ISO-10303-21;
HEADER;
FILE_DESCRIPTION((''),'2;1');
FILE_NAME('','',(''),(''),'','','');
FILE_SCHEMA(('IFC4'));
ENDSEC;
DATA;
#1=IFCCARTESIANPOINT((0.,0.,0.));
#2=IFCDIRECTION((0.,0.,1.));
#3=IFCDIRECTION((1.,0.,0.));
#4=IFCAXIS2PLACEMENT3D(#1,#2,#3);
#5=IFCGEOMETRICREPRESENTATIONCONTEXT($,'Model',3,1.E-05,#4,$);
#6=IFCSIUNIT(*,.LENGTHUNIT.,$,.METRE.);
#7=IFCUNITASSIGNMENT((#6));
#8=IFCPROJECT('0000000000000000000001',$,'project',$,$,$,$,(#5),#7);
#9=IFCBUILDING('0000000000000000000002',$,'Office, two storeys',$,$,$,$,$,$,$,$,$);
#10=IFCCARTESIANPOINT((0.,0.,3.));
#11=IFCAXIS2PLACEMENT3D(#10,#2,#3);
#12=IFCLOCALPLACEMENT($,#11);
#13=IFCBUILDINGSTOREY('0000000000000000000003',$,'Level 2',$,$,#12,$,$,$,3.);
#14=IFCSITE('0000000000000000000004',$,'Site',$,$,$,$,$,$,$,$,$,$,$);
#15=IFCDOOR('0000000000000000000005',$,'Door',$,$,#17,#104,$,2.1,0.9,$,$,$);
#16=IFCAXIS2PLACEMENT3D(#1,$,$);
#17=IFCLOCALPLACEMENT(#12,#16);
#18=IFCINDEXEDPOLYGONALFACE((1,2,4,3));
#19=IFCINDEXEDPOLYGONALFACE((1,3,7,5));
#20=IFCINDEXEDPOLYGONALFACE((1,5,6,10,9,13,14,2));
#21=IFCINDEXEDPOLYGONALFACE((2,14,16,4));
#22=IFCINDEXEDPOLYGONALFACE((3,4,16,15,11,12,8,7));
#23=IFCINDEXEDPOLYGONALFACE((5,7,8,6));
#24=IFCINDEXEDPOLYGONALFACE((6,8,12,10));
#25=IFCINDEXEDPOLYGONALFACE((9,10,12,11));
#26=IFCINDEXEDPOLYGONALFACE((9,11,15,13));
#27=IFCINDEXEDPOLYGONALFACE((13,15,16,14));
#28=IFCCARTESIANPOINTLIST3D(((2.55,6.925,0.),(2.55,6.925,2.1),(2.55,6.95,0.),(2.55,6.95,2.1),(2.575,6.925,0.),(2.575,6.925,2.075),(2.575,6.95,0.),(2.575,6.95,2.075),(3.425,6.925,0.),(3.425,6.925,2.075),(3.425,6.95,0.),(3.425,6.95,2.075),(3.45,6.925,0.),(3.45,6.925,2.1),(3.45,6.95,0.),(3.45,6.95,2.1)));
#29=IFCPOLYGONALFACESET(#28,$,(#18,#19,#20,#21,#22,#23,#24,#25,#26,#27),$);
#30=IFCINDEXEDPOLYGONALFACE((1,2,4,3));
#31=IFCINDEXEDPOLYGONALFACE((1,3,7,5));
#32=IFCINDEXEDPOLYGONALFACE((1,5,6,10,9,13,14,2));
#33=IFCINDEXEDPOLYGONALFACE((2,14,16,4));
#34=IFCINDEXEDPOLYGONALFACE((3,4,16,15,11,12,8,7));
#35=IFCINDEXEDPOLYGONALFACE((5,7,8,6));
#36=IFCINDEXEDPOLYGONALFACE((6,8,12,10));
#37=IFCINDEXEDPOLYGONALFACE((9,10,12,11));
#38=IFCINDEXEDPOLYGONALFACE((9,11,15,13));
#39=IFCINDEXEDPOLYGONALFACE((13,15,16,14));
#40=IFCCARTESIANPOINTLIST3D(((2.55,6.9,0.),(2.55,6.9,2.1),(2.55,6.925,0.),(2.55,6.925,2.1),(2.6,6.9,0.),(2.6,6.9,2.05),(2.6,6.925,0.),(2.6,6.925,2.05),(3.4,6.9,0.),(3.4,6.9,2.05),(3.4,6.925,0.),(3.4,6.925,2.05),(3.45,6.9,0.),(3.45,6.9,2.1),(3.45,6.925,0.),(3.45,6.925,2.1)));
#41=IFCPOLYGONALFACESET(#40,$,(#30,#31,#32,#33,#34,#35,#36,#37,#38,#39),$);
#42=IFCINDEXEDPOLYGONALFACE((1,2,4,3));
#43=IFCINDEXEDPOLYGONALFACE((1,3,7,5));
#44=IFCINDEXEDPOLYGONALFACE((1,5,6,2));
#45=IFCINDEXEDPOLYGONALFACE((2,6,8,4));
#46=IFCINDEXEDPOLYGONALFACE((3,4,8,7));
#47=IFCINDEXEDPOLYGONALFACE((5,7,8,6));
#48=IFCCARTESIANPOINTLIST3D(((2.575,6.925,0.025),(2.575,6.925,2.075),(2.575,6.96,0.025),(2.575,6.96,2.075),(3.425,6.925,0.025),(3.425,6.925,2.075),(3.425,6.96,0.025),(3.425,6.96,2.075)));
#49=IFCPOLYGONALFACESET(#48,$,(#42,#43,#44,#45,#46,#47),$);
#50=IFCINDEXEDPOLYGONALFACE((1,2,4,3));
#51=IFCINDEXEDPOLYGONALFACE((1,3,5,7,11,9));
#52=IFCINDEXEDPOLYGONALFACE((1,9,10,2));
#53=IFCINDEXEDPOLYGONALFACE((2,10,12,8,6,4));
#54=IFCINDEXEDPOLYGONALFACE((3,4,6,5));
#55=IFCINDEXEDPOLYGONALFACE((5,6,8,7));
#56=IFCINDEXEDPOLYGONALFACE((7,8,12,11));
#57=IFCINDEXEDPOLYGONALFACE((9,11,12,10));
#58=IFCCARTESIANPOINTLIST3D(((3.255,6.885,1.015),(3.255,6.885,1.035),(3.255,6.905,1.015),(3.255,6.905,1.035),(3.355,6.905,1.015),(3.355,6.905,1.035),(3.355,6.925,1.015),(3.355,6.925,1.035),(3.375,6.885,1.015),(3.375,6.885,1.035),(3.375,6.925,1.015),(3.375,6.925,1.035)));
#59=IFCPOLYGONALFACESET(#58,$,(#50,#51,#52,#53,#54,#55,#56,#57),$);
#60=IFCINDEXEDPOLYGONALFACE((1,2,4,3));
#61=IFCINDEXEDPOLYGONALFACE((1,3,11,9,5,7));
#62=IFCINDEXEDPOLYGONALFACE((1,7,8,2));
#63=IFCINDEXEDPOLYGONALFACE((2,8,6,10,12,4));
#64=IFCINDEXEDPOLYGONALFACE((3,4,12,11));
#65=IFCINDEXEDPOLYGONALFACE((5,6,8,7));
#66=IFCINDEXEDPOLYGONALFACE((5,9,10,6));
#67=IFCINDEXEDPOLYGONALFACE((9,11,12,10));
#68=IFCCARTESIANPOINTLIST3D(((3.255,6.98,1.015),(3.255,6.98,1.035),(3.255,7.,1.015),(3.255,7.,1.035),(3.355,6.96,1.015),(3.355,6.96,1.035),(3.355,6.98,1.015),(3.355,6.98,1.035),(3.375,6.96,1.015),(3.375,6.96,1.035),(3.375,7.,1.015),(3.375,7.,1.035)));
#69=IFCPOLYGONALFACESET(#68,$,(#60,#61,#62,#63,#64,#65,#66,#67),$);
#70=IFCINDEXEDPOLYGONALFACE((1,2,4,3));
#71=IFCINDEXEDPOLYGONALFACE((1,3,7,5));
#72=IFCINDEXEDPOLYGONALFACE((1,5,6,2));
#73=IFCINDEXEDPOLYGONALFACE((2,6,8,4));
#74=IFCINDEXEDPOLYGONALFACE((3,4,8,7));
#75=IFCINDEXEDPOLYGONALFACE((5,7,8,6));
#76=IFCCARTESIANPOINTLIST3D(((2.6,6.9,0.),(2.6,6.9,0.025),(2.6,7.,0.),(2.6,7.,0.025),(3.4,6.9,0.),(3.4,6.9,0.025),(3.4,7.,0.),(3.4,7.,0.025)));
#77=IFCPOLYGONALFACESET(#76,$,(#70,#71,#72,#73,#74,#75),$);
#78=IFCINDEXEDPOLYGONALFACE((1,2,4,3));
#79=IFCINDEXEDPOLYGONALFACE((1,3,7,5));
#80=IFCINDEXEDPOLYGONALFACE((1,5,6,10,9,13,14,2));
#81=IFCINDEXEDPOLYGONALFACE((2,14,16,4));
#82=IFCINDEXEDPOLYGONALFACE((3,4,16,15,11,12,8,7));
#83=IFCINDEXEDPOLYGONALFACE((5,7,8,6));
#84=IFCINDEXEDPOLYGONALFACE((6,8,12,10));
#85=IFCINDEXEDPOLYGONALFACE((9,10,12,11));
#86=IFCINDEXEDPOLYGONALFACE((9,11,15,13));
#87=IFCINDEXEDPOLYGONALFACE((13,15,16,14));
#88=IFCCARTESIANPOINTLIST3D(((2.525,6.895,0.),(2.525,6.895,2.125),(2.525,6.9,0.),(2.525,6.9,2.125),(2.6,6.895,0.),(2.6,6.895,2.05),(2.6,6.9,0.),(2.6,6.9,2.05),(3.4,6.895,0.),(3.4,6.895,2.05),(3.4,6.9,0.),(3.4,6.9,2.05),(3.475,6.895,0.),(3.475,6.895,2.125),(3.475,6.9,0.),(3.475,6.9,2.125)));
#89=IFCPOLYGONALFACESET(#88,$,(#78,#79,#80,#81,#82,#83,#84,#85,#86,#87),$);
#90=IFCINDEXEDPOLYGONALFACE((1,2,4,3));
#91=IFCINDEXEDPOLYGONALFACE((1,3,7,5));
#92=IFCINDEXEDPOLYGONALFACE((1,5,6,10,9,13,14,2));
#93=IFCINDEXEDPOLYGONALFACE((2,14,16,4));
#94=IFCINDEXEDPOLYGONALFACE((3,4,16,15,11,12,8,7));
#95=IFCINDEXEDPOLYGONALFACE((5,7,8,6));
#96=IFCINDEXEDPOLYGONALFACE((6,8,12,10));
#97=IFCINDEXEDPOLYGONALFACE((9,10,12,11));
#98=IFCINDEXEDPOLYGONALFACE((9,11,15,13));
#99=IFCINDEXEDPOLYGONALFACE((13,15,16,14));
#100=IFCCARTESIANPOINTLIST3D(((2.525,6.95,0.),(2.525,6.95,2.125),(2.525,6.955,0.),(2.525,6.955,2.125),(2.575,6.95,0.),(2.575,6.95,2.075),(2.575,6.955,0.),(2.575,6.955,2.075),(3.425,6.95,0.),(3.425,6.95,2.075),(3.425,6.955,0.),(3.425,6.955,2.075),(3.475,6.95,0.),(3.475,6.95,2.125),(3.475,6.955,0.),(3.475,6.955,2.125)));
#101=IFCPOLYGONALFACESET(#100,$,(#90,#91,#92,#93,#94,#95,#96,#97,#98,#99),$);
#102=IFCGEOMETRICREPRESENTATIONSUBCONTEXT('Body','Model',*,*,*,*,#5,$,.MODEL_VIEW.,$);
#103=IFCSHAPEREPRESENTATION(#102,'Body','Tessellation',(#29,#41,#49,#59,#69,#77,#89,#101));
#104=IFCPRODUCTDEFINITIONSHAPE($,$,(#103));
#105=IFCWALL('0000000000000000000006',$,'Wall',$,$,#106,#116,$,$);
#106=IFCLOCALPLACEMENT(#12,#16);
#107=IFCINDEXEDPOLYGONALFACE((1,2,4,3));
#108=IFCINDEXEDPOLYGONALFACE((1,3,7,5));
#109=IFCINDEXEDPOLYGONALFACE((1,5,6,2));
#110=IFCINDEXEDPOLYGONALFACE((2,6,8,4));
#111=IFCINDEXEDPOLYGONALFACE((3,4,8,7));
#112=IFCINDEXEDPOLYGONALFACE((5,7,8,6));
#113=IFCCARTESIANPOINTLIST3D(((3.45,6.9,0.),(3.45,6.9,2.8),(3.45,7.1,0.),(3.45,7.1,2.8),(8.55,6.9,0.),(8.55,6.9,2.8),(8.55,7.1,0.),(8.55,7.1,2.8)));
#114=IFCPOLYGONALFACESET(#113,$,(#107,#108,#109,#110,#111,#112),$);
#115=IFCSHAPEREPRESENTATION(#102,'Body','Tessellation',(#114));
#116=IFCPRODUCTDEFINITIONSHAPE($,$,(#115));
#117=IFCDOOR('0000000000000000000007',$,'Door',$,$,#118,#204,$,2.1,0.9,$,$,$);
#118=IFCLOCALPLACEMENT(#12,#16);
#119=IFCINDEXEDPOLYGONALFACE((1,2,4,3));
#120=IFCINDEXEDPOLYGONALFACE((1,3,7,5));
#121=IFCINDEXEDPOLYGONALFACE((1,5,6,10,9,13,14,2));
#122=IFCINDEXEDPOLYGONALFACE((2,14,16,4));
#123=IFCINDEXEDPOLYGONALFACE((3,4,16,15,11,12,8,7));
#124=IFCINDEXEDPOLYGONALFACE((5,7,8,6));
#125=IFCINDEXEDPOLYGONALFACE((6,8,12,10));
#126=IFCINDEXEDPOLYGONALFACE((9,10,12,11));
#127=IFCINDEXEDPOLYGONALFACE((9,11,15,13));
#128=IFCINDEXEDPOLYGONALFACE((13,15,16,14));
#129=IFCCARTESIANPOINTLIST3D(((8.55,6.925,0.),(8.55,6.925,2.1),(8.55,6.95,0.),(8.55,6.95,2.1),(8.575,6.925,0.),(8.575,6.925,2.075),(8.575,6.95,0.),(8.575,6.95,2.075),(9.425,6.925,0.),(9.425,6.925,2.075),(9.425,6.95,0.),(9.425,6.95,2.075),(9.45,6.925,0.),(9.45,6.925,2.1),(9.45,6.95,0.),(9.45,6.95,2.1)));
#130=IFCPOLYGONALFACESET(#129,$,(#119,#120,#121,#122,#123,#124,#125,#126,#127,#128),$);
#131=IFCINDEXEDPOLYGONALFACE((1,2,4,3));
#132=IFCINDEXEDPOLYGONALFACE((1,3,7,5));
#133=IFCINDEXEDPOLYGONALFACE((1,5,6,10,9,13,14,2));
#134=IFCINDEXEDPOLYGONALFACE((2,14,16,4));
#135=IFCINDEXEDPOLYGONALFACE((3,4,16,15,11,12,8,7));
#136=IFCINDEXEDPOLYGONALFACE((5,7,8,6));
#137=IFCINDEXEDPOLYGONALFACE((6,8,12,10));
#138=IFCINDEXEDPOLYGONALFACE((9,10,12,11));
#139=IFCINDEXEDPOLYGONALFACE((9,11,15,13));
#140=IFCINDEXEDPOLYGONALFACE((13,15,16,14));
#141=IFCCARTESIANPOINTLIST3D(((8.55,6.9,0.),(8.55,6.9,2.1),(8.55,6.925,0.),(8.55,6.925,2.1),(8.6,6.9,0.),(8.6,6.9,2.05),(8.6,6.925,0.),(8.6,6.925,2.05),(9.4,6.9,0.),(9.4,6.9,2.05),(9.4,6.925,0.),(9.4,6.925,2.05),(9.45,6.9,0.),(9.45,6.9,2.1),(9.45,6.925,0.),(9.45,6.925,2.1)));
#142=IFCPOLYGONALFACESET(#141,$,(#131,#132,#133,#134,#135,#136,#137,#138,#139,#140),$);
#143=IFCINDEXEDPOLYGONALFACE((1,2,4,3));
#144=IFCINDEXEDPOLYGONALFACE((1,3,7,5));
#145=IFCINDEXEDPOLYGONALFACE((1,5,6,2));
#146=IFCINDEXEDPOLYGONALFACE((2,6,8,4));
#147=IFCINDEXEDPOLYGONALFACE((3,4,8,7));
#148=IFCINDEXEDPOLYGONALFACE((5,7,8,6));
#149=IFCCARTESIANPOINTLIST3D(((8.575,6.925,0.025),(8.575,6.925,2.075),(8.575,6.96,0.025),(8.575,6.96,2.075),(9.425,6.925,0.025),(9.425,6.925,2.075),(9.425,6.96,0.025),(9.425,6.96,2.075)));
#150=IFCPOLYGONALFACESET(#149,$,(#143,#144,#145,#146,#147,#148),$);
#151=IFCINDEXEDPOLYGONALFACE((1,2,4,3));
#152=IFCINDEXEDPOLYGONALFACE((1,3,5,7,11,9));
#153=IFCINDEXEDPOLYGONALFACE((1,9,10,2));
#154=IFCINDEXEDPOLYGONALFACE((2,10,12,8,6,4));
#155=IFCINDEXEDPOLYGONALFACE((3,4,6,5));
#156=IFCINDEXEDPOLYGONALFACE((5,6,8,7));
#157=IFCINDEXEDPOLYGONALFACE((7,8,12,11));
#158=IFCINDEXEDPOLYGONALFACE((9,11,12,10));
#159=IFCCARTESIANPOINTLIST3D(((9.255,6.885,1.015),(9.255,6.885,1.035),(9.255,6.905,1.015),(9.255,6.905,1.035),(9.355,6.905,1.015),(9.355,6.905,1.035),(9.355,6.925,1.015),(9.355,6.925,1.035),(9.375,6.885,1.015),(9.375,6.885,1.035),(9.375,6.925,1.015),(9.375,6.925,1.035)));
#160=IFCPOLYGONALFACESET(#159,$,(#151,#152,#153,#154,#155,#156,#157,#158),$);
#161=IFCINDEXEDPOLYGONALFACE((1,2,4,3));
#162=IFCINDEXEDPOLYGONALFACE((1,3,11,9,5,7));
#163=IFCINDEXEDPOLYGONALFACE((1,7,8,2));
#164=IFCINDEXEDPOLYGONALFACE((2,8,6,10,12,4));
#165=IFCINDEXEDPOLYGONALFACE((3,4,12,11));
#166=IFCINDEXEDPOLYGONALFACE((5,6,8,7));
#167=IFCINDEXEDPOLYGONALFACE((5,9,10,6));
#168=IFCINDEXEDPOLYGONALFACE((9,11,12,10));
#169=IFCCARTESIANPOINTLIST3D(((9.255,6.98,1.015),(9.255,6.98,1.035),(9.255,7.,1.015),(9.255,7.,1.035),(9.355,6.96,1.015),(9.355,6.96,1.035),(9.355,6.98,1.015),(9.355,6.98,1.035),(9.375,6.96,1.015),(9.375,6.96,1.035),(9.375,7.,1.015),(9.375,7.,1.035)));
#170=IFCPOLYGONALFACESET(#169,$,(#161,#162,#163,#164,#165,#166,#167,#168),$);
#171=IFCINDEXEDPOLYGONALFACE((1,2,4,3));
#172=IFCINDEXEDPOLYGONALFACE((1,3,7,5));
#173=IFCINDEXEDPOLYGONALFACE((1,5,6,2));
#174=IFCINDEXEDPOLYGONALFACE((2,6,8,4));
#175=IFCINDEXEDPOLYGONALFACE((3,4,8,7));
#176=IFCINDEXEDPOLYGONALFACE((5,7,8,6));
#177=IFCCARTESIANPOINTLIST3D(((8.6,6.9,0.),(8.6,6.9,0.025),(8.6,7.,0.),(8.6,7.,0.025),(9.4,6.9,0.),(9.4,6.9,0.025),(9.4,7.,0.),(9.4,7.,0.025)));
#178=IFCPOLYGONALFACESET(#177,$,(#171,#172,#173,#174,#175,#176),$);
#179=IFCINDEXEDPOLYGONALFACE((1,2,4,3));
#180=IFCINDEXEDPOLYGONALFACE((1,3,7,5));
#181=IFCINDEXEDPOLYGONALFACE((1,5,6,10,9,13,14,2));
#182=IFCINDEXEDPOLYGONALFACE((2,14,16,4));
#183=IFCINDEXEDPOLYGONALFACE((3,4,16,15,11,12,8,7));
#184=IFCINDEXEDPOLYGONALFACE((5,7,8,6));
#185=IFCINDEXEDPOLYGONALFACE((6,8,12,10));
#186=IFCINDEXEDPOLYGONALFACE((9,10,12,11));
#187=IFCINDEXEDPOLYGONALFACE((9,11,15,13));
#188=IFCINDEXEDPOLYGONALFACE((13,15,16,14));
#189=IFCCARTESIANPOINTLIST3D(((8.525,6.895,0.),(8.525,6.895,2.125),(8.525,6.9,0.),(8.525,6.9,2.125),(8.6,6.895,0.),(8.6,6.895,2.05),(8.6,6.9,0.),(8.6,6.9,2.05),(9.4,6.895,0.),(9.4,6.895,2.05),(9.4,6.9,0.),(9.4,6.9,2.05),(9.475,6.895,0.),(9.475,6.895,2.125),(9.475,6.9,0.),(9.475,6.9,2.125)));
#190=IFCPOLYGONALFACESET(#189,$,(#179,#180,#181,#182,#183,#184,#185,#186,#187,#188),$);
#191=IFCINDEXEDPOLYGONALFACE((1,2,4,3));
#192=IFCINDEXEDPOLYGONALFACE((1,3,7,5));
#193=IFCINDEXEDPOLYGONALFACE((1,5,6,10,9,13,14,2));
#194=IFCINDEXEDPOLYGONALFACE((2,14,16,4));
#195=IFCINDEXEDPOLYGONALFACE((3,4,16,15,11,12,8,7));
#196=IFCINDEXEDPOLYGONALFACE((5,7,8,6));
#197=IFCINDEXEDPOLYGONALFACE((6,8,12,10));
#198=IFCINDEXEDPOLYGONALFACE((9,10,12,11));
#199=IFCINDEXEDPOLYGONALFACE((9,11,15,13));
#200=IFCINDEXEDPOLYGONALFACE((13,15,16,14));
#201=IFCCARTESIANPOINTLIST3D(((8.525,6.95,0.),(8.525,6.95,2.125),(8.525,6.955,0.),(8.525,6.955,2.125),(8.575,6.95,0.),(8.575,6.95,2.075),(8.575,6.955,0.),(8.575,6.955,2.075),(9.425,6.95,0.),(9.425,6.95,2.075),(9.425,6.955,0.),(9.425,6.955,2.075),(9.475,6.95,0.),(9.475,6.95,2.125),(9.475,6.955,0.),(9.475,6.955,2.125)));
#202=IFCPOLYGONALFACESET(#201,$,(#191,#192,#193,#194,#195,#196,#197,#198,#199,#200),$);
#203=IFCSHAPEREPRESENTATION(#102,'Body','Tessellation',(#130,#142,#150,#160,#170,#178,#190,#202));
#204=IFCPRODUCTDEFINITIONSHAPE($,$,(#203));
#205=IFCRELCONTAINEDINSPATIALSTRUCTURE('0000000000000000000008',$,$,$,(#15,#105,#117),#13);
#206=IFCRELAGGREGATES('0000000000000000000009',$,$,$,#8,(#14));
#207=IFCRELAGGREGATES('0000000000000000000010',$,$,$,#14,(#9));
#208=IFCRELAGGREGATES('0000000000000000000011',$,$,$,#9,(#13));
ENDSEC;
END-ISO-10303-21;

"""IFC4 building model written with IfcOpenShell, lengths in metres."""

from ifc_helpers import new_model, si_unit, frame, origin_with_axes, place, context, subcontext, project, spatial, line, indexed_curve, outline, extrude, element, save


model = new_model("IFC4")

# Units and contexts
model_context = context("Model", 3, precision=1e-05, world=origin_with_axes())
body_context = subcontext(model_context, "Body", "Model", "MODEL_VIEW")
ifc_project = project(units=[si_unit("LENGTHUNIT", "METRE")], contexts=[model_context])

# Site, building, storey
site = spatial("IfcSite", under=ifc_project, Name="Site")
building = spatial("IfcBuilding", under=site, Name="Office, two storeys")
storey_placement = place(None, frame((0.0, 0.0, 3.0), z_axis=(0.0, 0.0, 1.0), x_axis=(1.0, 0.0, 0.0)))
storey = spatial("IfcBuildingStorey", under=building, at=storey_placement, Name="Level 2", Elevation=3.0)

# Door
door_1_placement = place(storey_placement, frame((2.55, 6.9, 0.0), z_axis=(0.0, 0.0, 1.0), x_axis=(1.0, 0.0, 0.0)))
element("IfcDoor", 1, at=door_1_placement, inside=storey, Name="Door", OverallHeight=2.1, OverallWidth=0.9, context=body_context, shape_type="SweptSolid", body=[
    extrude(outline(indexed_curve([(0.0, 0.0), (0.0, 2.1), (0.9, 2.1), (0.9, 0.0), (0.875, 0.0), (0.875, 2.075), (0.025, 2.075), (0.025, 0.0)], segments=[line(1, 2, 3, 4, 5, 6, 7, 8, 1)])), frame((0.0, 0.025, 0.0), z_axis=(0.0, -1.0, 0.0), x_axis=(1.0, 0.0, 0.0)), (0.0, 0.0, -1.0), 0.025),
    extrude(outline(indexed_curve([(0.0, 0.0), (0.0, 2.1), (0.9, 2.1), (0.9, 0.0), (0.85, 0.0), (0.85, 2.05), (0.05, 2.05), (0.05, 0.0)], segments=[line(1, 2, 3, 4, 5, 6, 7, 8, 1)])), frame((0.0, 0.0, 0.0), z_axis=(0.0, -1.0, 0.0), x_axis=(1.0, 0.0, 0.0)), (0.0, 0.0, -1.0), 0.025),
    extrude(outline(indexed_curve([(0.0, 0.0), (0.85, 0.0), (0.85, 0.035), (0.0, 0.035)], segments=[line(1, 2, 3, 4, 1)])), frame((0.025, 0.025, 0.025), z_axis=(0.0, 0.0, 1.0), x_axis=(1.0, 0.0, 0.0)), (0.0, 0.0, 1.0), 2.05),
    extrude(outline(indexed_curve([(0.0, 0.0), (0.0, -0.04), (-0.12, -0.04), (-0.12, -0.02), (-0.02, -0.02), (-0.02, 0.0)], segments=[line(1, 2, 3, 4, 5, 6, 1)])), frame((0.825, 0.025, 1.015), z_axis=(0.0, 0.0, 1.0), x_axis=(1.0, 0.0, 0.0)), (0.0, 0.0, 1.0), 0.02),
    extrude(outline(indexed_curve([(0.0, 0.0), (0.0, 0.04), (-0.12, 0.04), (-0.12, 0.02), (-0.02, 0.02), (-0.02, 0.0)], segments=[line(1, 2, 3, 4, 5, 6, 1)])), frame((0.825, 0.06, 1.015), z_axis=(0.0, 0.0, 1.0), x_axis=(1.0, 0.0, 0.0)), (0.0, 0.0, 1.0), 0.02),
    extrude(outline(indexed_curve([(0.0, 0.0), (0.8, 0.0), (0.8, 0.1), (0.0, 0.1)], segments=[line(1, 2, 3, 4, 1)])), frame((0.05, 0.0, 0.0), z_axis=(0.0, 0.0, 1.0), x_axis=(1.0, 0.0, 0.0)), (0.0, 0.0, 1.0), 0.025),
    extrude(outline(indexed_curve([(0.0, 0.0), (0.0, 2.125), (0.95, 2.125), (0.95, 0.0), (0.875, 0.0), (0.875, 2.05), (0.075, 2.05), (0.075, 0.0)], segments=[line(1, 2, 3, 4, 5, 6, 7, 8, 1)])), frame((-0.025, -0.005, 0.0), z_axis=(0.0, -1.0, 0.0), x_axis=(1.0, 0.0, 0.0)), (0.0, 0.0, -1.0), 0.005),
    extrude(outline(indexed_curve([(0.0, 0.0), (0.0, 2.125), (0.95, 2.125), (0.95, 0.0), (0.9, 0.0), (0.9, 2.075), (0.05, 2.075), (0.05, 0.0)], segments=[line(1, 2, 3, 4, 5, 6, 7, 8, 1)])), frame((-0.025, 0.05, 0.0), z_axis=(0.0, -1.0, 0.0), x_axis=(1.0, 0.0, 0.0)), (0.0, 0.0, -1.0), 0.005),
])

# Wall
wall_1_placement = place(storey_placement, frame((3.45, 7.0, 0.0), z_axis=(0.0, 0.0, 1.0), x_axis=(1.0, 0.0, 0.0)))
element("IfcWall", 2, at=wall_1_placement, inside=storey, Name="Wall", context=body_context, shape_type="SweptSolid", body=[
    extrude(outline(indexed_curve([(0.0, 0.0), (0.0, 0.2), (5.1, 0.2), (5.1, 0.0), (0.0, 0.0)], self_intersect=False)), frame((0.0, -0.1, 0.0), z_axis=(0.0, 0.0, 1.0), x_axis=(1.0, 0.0, 0.0)), (0.0, 0.0, 1.0), 2.8),
])

# Door
door_2_placement = place(storey_placement, frame((8.55, 6.9, 0.0), z_axis=(0.0, 0.0, 1.0), x_axis=(1.0, 0.0, 0.0)))
element("IfcDoor", 3, at=door_2_placement, inside=storey, Name="Door", OverallHeight=2.1, OverallWidth=0.9, context=body_context, shape_type="SweptSolid", body=[
    extrude(outline(indexed_curve([(0.0, 0.0), (0.0, 2.1), (0.9, 2.1), (0.9, 0.0), (0.875, 0.0), (0.875, 2.075), (0.025, 2.075), (0.025, 0.0)], segments=[line(1, 2, 3, 4, 5, 6, 7, 8, 1)])), frame((0.0, 0.025, 0.0), z_axis=(0.0, -1.0, 0.0), x_axis=(1.0, 0.0, 0.0)), (0.0, 0.0, -1.0), 0.025),
    extrude(outline(indexed_curve([(0.0, 0.0), (0.0, 2.1), (0.9, 2.1), (0.9, 0.0), (0.85, 0.0), (0.85, 2.05), (0.05, 2.05), (0.05, 0.0)], segments=[line(1, 2, 3, 4, 5, 6, 7, 8, 1)])), frame((0.0, 0.0, 0.0), z_axis=(0.0, -1.0, 0.0), x_axis=(1.0, 0.0, 0.0)), (0.0, 0.0, -1.0), 0.025),
    extrude(outline(indexed_curve([(0.0, 0.0), (0.85, 0.0), (0.85, 0.035), (0.0, 0.035)], segments=[line(1, 2, 3, 4, 1)])), frame((0.025, 0.025, 0.025), z_axis=(0.0, 0.0, 1.0), x_axis=(1.0, 0.0, 0.0)), (0.0, 0.0, 1.0), 2.05),
    extrude(outline(indexed_curve([(0.0, 0.0), (0.0, -0.04), (-0.12, -0.04), (-0.12, -0.02), (-0.02, -0.02), (-0.02, 0.0)], segments=[line(1, 2, 3, 4, 5, 6, 1)])), frame((0.825, 0.025, 1.015), z_axis=(0.0, 0.0, 1.0), x_axis=(1.0, 0.0, 0.0)), (0.0, 0.0, 1.0), 0.02),
    extrude(outline(indexed_curve([(0.0, 0.0), (0.0, 0.04), (-0.12, 0.04), (-0.12, 0.02), (-0.02, 0.02), (-0.02, 0.0)], segments=[line(1, 2, 3, 4, 5, 6, 1)])), frame((0.825, 0.06, 1.015), z_axis=(0.0, 0.0, 1.0), x_axis=(1.0, 0.0, 0.0)), (0.0, 0.0, 1.0), 0.02),
    extrude(outline(indexed_curve([(0.0, 0.0), (0.8, 0.0), (0.8, 0.1), (0.0, 0.1)], segments=[line(1, 2, 3, 4, 1)])), frame((0.05, 0.0, 0.0), z_axis=(0.0, 0.0, 1.0), x_axis=(1.0, 0.0, 0.0)), (0.0, 0.0, 1.0), 0.025),
    extrude(outline(indexed_curve([(0.0, 0.0), (0.0, 2.125), (0.95, 2.125), (0.95, 0.0), (0.875, 0.0), (0.875, 2.05), (0.075, 2.05), (0.075, 0.0)], segments=[line(1, 2, 3, 4, 5, 6, 7, 8, 1)])), frame((-0.025, -0.005, 0.0), z_axis=(0.0, -1.0, 0.0), x_axis=(1.0, 0.0, 0.0)), (0.0, 0.0, -1.0), 0.005),
    extrude(outline(indexed_curve([(0.0, 0.0), (0.0, 2.125), (0.95, 2.125), (0.95, 0.0), (0.9, 0.0), (0.9, 2.075), (0.05, 2.075), (0.05, 0.0)], segments=[line(1, 2, 3, 4, 5, 6, 7, 8, 1)])), frame((-0.025, 0.05, 0.0), z_axis=(0.0, -1.0, 0.0), x_axis=(1.0, 0.0, 0.0)), (0.0, 0.0, -1.0), 0.005),
])

save(model, "model.ifc")
